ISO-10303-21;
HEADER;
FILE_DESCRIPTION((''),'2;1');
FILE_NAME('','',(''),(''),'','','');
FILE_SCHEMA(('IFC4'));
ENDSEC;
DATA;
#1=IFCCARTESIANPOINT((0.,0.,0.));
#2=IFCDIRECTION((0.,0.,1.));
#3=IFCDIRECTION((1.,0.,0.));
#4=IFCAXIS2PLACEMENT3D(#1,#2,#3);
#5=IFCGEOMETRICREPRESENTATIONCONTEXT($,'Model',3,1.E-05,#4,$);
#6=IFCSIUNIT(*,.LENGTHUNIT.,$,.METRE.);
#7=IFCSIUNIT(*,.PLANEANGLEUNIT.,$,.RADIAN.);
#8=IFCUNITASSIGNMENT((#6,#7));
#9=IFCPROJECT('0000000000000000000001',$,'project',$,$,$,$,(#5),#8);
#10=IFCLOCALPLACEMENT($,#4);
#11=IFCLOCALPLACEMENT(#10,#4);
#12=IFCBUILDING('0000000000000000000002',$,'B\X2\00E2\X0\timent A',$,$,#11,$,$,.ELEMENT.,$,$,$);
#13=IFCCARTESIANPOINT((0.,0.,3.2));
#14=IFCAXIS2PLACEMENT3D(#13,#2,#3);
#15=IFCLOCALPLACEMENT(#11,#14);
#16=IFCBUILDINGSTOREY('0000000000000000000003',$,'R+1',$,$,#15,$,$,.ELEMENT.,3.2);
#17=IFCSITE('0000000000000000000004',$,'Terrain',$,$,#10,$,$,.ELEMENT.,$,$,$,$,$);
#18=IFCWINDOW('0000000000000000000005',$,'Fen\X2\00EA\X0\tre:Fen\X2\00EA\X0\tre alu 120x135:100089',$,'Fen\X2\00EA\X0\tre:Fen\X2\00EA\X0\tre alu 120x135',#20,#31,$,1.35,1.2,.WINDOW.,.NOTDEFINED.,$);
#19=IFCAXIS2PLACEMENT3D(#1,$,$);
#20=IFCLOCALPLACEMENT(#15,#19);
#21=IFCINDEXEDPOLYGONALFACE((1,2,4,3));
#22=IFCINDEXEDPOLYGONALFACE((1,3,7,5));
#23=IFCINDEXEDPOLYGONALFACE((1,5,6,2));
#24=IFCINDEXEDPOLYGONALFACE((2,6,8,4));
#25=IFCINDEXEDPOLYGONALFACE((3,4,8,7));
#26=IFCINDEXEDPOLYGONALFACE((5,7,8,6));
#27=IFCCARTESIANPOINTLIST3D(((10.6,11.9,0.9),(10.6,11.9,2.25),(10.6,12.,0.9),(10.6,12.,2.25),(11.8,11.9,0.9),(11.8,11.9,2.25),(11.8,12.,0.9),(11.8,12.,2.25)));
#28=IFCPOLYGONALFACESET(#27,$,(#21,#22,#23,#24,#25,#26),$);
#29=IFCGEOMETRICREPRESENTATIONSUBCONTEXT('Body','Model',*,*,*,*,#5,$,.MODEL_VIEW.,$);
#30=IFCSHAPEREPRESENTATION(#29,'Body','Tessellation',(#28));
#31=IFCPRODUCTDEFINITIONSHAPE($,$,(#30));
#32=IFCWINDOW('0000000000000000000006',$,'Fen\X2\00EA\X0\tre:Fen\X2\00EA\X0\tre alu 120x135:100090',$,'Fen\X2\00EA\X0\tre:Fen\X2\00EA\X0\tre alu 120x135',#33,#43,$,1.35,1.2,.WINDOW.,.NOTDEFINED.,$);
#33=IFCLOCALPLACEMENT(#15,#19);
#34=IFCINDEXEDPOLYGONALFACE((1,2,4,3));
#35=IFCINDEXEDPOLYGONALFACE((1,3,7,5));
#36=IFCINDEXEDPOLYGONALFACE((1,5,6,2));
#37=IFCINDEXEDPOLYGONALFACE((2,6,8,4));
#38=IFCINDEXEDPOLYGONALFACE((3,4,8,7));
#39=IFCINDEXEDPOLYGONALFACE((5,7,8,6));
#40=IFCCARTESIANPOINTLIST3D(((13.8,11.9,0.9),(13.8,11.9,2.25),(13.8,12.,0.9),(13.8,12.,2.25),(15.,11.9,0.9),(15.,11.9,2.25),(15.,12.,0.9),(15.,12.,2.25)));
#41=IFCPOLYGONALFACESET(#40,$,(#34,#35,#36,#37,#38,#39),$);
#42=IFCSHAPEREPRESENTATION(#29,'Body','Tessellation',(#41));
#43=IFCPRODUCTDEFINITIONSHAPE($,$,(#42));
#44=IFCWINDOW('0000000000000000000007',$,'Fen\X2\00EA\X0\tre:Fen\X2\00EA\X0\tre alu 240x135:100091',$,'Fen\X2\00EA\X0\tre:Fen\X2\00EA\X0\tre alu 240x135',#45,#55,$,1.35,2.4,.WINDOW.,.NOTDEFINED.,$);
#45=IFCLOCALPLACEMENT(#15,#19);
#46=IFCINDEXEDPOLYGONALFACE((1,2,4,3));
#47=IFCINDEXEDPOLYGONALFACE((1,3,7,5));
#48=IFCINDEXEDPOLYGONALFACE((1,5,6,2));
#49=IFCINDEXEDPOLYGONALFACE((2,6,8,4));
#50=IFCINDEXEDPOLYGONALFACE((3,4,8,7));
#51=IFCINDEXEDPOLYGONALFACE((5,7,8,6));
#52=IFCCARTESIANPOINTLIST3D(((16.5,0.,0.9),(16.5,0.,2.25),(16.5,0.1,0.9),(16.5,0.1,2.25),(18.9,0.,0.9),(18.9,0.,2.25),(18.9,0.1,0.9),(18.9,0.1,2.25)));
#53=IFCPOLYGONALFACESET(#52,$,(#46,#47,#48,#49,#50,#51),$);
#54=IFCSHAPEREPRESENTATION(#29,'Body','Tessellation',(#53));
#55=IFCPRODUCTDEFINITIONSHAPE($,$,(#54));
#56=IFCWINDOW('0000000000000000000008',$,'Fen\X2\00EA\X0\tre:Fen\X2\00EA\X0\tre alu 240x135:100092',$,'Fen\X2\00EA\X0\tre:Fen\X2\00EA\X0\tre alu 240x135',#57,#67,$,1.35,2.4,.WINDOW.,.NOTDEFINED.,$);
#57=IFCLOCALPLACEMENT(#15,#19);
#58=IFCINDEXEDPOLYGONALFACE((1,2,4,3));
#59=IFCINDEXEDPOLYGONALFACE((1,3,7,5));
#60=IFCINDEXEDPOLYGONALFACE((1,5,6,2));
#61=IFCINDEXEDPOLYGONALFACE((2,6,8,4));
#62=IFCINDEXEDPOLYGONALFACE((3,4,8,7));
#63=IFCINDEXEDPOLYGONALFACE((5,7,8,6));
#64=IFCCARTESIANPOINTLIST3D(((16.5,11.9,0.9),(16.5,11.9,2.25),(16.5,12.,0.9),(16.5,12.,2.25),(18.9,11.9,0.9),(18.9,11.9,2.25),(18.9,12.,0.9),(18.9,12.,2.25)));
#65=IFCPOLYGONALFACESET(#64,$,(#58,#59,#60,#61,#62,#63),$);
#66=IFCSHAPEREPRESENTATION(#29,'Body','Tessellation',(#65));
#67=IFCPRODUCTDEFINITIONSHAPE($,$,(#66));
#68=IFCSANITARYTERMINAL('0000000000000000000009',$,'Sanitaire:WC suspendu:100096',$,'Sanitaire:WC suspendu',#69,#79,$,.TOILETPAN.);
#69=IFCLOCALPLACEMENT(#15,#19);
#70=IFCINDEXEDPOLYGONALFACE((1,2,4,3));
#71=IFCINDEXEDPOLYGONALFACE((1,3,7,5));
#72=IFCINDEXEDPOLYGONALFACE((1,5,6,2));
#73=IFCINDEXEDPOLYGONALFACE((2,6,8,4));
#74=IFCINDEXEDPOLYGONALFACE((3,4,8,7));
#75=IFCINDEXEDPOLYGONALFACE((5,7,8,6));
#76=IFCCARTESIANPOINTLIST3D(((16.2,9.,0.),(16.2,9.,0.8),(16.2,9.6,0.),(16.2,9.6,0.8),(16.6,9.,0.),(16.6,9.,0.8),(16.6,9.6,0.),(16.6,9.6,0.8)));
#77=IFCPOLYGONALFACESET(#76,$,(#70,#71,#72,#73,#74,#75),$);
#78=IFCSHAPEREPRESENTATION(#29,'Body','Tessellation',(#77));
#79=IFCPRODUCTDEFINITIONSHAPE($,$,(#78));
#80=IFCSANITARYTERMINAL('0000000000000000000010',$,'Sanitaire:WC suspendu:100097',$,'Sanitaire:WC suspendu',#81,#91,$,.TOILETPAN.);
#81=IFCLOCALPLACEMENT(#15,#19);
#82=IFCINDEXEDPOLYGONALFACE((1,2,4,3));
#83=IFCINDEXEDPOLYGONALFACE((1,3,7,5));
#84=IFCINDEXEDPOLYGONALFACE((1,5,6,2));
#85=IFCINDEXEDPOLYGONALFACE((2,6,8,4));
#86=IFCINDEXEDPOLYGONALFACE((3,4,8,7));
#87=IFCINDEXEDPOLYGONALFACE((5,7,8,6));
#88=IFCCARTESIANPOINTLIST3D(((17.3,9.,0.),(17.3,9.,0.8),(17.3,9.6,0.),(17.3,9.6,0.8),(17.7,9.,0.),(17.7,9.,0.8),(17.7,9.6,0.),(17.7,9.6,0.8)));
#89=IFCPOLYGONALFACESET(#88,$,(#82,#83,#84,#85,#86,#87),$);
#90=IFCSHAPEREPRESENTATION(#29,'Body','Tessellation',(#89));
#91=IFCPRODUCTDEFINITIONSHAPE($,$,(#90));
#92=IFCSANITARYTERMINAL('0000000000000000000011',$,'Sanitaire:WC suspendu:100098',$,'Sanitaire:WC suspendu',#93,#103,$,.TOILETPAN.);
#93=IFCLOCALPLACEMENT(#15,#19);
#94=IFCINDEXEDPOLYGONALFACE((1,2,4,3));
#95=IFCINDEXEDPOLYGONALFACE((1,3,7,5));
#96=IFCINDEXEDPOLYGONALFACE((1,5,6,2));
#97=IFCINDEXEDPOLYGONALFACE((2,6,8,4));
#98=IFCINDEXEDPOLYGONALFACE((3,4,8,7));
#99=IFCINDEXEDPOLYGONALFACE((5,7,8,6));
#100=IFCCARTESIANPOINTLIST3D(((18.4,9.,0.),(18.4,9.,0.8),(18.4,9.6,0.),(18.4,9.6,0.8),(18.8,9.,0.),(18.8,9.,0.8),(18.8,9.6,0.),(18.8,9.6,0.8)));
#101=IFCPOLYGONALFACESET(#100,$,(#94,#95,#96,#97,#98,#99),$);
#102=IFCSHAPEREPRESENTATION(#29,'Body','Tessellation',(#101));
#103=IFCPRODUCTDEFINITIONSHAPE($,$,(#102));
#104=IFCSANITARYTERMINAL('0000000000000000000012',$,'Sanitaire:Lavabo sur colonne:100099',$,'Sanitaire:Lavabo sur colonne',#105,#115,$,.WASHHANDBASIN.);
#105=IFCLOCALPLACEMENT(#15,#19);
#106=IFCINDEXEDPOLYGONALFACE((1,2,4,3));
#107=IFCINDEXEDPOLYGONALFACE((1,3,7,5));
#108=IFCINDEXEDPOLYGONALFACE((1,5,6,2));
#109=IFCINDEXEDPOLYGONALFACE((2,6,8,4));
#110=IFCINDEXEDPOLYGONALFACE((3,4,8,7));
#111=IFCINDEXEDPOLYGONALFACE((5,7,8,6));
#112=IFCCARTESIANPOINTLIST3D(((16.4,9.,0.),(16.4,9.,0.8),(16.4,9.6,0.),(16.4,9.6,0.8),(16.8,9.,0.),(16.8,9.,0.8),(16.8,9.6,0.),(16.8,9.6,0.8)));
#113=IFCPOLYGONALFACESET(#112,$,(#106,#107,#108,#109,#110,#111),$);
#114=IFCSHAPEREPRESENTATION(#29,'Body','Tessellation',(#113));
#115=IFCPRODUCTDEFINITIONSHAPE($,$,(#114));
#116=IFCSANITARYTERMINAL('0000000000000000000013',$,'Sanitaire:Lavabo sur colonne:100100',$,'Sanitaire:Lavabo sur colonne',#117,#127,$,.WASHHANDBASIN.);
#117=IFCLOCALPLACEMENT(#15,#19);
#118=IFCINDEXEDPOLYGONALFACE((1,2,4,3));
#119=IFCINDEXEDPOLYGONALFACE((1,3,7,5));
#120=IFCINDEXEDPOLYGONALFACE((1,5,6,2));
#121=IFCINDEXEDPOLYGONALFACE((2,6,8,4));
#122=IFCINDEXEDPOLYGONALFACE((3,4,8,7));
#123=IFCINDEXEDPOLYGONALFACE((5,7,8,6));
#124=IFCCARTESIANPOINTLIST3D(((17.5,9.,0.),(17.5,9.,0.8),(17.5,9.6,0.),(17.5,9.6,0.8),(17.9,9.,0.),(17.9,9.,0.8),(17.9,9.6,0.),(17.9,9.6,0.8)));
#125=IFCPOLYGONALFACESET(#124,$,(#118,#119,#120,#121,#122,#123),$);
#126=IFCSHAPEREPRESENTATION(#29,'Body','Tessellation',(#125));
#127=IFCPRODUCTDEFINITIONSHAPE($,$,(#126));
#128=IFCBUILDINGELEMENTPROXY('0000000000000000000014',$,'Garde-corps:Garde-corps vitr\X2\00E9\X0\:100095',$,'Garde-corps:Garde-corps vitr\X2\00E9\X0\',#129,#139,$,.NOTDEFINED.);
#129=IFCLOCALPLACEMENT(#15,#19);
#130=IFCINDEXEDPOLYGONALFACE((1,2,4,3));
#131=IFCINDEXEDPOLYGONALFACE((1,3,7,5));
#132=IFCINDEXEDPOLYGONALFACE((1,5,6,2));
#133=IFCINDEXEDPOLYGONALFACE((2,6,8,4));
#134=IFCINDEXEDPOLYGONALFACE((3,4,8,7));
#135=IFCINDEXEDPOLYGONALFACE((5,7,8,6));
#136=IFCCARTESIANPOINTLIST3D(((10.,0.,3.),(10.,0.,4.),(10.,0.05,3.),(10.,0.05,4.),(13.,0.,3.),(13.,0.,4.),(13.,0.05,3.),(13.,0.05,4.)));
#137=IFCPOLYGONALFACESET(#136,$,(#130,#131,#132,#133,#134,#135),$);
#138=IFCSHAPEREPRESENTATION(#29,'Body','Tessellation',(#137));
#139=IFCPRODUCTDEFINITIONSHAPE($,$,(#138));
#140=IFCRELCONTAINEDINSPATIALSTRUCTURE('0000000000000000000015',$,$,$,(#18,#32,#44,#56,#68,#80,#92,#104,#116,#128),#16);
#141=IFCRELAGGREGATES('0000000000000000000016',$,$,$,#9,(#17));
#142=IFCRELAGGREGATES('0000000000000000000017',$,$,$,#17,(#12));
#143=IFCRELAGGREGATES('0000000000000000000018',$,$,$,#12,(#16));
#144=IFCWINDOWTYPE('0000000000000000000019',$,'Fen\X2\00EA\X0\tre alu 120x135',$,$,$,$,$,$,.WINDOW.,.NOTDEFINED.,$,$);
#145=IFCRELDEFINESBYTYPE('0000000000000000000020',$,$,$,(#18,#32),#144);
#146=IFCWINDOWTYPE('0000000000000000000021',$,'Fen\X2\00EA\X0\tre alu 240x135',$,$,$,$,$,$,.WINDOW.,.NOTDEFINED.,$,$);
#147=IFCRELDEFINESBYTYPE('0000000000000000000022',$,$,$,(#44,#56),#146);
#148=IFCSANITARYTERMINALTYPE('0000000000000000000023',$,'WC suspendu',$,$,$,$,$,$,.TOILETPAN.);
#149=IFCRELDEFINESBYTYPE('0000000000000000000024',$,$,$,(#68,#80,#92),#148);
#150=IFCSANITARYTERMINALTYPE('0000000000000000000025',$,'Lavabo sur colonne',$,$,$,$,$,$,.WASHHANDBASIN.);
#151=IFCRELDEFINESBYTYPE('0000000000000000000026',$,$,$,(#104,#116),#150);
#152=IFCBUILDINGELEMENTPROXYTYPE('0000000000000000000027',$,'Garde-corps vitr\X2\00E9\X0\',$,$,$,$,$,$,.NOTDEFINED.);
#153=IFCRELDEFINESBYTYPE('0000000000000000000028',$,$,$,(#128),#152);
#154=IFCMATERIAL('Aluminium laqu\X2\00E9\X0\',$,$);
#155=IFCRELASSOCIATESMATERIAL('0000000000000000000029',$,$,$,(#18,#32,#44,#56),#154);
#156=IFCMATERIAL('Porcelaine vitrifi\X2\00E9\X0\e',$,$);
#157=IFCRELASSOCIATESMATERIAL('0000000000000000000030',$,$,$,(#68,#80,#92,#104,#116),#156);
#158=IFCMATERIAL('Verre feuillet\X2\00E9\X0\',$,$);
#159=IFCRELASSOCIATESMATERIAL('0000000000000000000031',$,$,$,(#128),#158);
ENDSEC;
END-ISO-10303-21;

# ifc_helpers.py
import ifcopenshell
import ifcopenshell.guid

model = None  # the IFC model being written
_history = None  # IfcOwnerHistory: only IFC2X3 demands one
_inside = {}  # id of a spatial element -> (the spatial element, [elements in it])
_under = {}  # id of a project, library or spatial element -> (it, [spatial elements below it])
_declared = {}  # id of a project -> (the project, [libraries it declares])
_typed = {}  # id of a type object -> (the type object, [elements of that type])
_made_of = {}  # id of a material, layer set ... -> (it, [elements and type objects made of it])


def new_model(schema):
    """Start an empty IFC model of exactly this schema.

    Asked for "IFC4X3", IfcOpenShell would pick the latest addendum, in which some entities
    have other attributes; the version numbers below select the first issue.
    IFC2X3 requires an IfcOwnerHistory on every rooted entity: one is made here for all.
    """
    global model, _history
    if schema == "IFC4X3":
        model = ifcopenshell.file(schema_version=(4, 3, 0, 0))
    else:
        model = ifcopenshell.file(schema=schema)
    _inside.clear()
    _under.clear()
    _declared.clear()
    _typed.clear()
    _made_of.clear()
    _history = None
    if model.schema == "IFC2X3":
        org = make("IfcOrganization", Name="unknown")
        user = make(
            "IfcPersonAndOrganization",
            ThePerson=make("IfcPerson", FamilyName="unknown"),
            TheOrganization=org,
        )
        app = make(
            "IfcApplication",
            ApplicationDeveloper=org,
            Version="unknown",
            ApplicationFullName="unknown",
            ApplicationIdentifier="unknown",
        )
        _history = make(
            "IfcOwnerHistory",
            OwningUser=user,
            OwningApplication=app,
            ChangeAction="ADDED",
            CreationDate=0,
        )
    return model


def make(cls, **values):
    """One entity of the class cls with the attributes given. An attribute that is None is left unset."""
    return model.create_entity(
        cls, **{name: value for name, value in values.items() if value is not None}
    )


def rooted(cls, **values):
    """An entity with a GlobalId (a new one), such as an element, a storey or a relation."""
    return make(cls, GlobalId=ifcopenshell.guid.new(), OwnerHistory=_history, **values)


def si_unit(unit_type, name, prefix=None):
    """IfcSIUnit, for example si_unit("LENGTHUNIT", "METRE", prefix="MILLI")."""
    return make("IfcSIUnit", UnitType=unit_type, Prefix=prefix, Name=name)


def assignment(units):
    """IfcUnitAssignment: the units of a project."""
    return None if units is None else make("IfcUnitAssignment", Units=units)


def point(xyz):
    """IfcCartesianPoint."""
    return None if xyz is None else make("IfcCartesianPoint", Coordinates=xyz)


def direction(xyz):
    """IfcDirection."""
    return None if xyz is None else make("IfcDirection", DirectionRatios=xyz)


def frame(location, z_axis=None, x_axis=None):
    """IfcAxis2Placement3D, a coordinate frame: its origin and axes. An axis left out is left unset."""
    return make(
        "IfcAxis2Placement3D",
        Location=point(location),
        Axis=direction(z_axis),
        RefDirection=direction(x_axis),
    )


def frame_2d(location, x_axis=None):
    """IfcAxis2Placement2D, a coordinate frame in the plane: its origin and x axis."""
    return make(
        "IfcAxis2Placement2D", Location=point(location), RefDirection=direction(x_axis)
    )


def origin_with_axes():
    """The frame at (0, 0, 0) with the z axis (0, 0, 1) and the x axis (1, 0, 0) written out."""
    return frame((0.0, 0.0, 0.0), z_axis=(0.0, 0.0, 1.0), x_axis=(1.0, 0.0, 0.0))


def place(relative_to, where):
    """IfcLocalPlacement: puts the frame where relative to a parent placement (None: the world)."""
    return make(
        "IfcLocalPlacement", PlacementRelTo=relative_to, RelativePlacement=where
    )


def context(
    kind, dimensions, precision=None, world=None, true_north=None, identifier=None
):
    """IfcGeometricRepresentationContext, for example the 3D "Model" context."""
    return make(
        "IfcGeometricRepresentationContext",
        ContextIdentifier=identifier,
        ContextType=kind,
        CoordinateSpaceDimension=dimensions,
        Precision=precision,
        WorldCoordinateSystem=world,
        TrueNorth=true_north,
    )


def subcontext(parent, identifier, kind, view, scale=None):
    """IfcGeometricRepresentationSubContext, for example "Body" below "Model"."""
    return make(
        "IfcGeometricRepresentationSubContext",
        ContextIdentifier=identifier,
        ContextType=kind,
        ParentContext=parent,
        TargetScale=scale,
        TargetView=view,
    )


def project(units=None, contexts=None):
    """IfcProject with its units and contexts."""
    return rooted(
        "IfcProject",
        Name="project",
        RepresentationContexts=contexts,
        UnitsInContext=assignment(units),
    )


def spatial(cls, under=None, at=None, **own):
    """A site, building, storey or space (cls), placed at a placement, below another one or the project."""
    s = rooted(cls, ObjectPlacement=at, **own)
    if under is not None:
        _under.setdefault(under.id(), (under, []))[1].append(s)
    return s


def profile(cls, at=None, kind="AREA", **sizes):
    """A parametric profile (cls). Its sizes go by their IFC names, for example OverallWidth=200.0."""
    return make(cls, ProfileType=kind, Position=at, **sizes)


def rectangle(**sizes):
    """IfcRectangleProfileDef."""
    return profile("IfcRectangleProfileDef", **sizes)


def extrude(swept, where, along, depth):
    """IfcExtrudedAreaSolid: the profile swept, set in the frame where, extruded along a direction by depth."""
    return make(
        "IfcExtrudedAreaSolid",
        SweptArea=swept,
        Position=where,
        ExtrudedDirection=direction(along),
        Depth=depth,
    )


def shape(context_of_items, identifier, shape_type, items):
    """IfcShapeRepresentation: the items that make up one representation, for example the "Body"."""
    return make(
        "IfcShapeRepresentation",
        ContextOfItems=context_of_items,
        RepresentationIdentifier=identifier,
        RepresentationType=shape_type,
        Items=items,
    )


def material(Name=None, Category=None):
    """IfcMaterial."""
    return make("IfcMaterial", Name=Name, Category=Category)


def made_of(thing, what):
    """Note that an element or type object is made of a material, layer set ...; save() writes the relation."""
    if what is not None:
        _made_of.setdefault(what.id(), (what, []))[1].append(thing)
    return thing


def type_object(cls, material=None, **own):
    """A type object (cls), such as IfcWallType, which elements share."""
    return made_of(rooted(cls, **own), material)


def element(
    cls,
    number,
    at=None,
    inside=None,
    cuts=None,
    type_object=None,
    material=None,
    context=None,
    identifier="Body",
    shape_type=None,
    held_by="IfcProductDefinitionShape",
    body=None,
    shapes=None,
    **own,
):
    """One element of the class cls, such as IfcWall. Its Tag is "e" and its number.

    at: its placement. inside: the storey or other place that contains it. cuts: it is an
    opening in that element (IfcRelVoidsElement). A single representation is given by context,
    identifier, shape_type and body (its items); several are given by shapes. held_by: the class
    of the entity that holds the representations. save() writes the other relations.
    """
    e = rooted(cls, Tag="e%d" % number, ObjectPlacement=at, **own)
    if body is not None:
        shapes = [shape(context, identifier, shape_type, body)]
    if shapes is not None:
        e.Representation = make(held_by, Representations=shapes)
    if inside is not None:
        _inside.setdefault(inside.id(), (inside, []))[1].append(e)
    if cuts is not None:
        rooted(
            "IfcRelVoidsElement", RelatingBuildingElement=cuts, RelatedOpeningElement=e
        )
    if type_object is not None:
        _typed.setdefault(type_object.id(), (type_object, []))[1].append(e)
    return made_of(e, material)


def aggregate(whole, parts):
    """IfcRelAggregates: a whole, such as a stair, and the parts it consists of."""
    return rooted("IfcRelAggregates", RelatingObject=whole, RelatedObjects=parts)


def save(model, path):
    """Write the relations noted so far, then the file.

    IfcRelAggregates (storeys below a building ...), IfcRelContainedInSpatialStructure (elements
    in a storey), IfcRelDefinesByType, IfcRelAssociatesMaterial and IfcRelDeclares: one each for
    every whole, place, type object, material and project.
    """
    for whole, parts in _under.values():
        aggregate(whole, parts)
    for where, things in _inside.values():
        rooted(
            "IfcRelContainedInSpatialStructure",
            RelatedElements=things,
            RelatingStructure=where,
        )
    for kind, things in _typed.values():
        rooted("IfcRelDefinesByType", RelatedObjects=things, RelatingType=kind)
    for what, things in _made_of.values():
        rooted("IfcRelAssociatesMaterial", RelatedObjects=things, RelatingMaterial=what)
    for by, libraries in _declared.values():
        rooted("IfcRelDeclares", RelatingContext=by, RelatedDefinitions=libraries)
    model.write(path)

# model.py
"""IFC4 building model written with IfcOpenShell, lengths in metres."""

from ifc_helpers import new_model, si_unit, frame, frame_2d, origin_with_axes, place, context, subcontext, project, spatial, rectangle, extrude, material, type_object, element, save


model = new_model("IFC4")

# Units and contexts
model_context = context("Model", 3, precision=1e-05, world=origin_with_axes())
body_context = subcontext(model_context, "Body", "Model", "MODEL_VIEW")
ifc_project = project(units=[si_unit("LENGTHUNIT", "METRE"), si_unit("PLANEANGLEUNIT", "RADIAN")], contexts=[model_context])

# Site, building, storey
site_placement = place(None, origin_with_axes())
site = spatial("IfcSite", under=ifc_project, at=site_placement, Name="Terrain", CompositionType="ELEMENT")
building_placement = place(site_placement, origin_with_axes())
building = spatial("IfcBuilding", under=site, at=building_placement, Name="Bâtiment A", CompositionType="ELEMENT")
storey_placement = place(building_placement, frame((0.0, 0.0, 3.2), z_axis=(0.0, 0.0, 1.0), x_axis=(1.0, 0.0, 0.0)))
storey = spatial("IfcBuildingStorey", under=building, at=storey_placement, Name="R+1", CompositionType="ELEMENT", Elevation=3.2)

# Windows
ifc_material_1 = material(Name="Aluminium laqué")
window_type_1 = type_object("IfcWindowType", Name="Fenêtre alu 120x135", PartitioningType="NOTDEFINED", PredefinedType="WINDOW")
for number, where, z_axis, x_axis, name in (
    (1, (10.6, 11.9, 0.9), (0.0, 0.0, 1.0), (1.0, 0.0, 0.0), "Fenêtre:Fenêtre alu 120x135:100089"),
    (2, (13.8, 11.9, 0.9), (0.0, 0.0, 1.0), (1.0, 0.0, 0.0), "Fenêtre:Fenêtre alu 120x135:100090"),
):
    element("IfcWindow", number, at=place(storey_placement, frame(where, z_axis=z_axis, x_axis=x_axis)), inside=storey, type_object=window_type_1, material=ifc_material_1, Name=name, ObjectType="Fenêtre:Fenêtre alu 120x135", OverallHeight=1.35, OverallWidth=1.2, PartitioningType="NOTDEFINED", PredefinedType="WINDOW", context=body_context, shape_type="SweptSolid", body=[
        extrude(rectangle(XDim=1.2, YDim=0.1, at=frame_2d((0.6, 0.05))), origin_with_axes(), (0.0, 0.0, 1.0), 1.35),
    ])
window_type_2 = type_object("IfcWindowType", Name="Fenêtre alu 240x135", PartitioningType="NOTDEFINED", PredefinedType="WINDOW")
for number, where, z_axis, x_axis, name in (
    (3, (16.5, 0.0, 0.9), (0.0, 0.0, 1.0), (1.0, 0.0, 0.0), "Fenêtre:Fenêtre alu 240x135:100091"),
    (4, (16.5, 11.9, 0.9), (0.0, 0.0, 1.0), (1.0, 0.0, 0.0), "Fenêtre:Fenêtre alu 240x135:100092"),
):
    element("IfcWindow", number, at=place(storey_placement, frame(where, z_axis=z_axis, x_axis=x_axis)), inside=storey, type_object=window_type_2, material=ifc_material_1, Name=name, ObjectType="Fenêtre:Fenêtre alu 240x135", OverallHeight=1.35, OverallWidth=2.4, PartitioningType="NOTDEFINED", PredefinedType="WINDOW", context=body_context, shape_type="SweptSolid", body=[
        extrude(rectangle(XDim=2.4, YDim=0.1, at=frame_2d((1.2, 0.05))), origin_with_axes(), (0.0, 0.0, 1.0), 1.35),
    ])

# Sanitary terminals
ifc_material_2 = material(Name="Porcelaine vitrifiée")
sanitary_terminal_type_1 = type_object("IfcSanitaryTerminalType", Name="WC suspendu", PredefinedType="TOILETPAN")
for number, where, z_axis, x_axis, name in (
    (5, (16.2, 9.0, 0.0), (0.0, 0.0, 1.0), (1.0, 0.0, 0.0), "Sanitaire:WC suspendu:100096"),
    (6, (17.3, 9.0, 0.0), (0.0, 0.0, 1.0), (1.0, 0.0, 0.0), "Sanitaire:WC suspendu:100097"),
    (7, (18.4, 9.0, 0.0), (0.0, 0.0, 1.0), (1.0, 0.0, 0.0), "Sanitaire:WC suspendu:100098"),
):
    element("IfcSanitaryTerminal", number, at=place(storey_placement, frame(where, z_axis=z_axis, x_axis=x_axis)), inside=storey, type_object=sanitary_terminal_type_1, material=ifc_material_2, Name=name, ObjectType="Sanitaire:WC suspendu", PredefinedType="TOILETPAN", context=body_context, shape_type="SweptSolid", body=[
        extrude(rectangle(XDim=0.4, YDim=0.6, at=frame_2d((0.2, 0.3))), origin_with_axes(), (0.0, 0.0, 1.0), 0.8),
    ])
sanitary_terminal_type_2 = type_object("IfcSanitaryTerminalType", Name="Lavabo sur colonne", PredefinedType="WASHHANDBASIN")
for number, where, z_axis, x_axis, name in (
    (8, (16.4, 9.0, 0.0), (0.0, 0.0, 1.0), (1.0, 0.0, 0.0), "Sanitaire:Lavabo sur colonne:100099"),
    (9, (17.5, 9.0, 0.0), (0.0, 0.0, 1.0), (1.0, 0.0, 0.0), "Sanitaire:Lavabo sur colonne:100100"),
):
    element("IfcSanitaryTerminal", number, at=place(storey_placement, frame(where, z_axis=z_axis, x_axis=x_axis)), inside=storey, type_object=sanitary_terminal_type_2, material=ifc_material_2, Name=name, ObjectType="Sanitaire:Lavabo sur colonne", PredefinedType="WASHHANDBASIN", context=body_context, shape_type="SweptSolid", body=[
        extrude(rectangle(XDim=0.4, YDim=0.6, at=frame_2d((0.2, 0.3))), origin_with_axes(), (0.0, 0.0, 1.0), 0.8),
    ])

# Building element proxy
ifc_material_3 = material(Name="Verre feuilleté")
building_element_proxy_type = type_object("IfcBuildingElementProxyType", Name="Garde-corps vitré", PredefinedType="NOTDEFINED")
proxy_placement = place(storey_placement, frame((10.0, 0.0, 3.0), z_axis=(0.0, 0.0, 1.0), x_axis=(1.0, 0.0, 0.0)))
element("IfcBuildingElementProxy", 10, at=proxy_placement, inside=storey, type_object=building_element_proxy_type, material=ifc_material_3, Name="Garde-corps:Garde-corps vitré:100095", ObjectType="Garde-corps:Garde-corps vitré", PredefinedType="NOTDEFINED", context=body_context, shape_type="SweptSolid", body=[
    extrude(rectangle(XDim=3.0, YDim=0.05, at=frame_2d((1.5, 0.025))), origin_with_axes(), (0.0, 0.0, 1.0), 1.0),
])

save(model, "model.ifc")
